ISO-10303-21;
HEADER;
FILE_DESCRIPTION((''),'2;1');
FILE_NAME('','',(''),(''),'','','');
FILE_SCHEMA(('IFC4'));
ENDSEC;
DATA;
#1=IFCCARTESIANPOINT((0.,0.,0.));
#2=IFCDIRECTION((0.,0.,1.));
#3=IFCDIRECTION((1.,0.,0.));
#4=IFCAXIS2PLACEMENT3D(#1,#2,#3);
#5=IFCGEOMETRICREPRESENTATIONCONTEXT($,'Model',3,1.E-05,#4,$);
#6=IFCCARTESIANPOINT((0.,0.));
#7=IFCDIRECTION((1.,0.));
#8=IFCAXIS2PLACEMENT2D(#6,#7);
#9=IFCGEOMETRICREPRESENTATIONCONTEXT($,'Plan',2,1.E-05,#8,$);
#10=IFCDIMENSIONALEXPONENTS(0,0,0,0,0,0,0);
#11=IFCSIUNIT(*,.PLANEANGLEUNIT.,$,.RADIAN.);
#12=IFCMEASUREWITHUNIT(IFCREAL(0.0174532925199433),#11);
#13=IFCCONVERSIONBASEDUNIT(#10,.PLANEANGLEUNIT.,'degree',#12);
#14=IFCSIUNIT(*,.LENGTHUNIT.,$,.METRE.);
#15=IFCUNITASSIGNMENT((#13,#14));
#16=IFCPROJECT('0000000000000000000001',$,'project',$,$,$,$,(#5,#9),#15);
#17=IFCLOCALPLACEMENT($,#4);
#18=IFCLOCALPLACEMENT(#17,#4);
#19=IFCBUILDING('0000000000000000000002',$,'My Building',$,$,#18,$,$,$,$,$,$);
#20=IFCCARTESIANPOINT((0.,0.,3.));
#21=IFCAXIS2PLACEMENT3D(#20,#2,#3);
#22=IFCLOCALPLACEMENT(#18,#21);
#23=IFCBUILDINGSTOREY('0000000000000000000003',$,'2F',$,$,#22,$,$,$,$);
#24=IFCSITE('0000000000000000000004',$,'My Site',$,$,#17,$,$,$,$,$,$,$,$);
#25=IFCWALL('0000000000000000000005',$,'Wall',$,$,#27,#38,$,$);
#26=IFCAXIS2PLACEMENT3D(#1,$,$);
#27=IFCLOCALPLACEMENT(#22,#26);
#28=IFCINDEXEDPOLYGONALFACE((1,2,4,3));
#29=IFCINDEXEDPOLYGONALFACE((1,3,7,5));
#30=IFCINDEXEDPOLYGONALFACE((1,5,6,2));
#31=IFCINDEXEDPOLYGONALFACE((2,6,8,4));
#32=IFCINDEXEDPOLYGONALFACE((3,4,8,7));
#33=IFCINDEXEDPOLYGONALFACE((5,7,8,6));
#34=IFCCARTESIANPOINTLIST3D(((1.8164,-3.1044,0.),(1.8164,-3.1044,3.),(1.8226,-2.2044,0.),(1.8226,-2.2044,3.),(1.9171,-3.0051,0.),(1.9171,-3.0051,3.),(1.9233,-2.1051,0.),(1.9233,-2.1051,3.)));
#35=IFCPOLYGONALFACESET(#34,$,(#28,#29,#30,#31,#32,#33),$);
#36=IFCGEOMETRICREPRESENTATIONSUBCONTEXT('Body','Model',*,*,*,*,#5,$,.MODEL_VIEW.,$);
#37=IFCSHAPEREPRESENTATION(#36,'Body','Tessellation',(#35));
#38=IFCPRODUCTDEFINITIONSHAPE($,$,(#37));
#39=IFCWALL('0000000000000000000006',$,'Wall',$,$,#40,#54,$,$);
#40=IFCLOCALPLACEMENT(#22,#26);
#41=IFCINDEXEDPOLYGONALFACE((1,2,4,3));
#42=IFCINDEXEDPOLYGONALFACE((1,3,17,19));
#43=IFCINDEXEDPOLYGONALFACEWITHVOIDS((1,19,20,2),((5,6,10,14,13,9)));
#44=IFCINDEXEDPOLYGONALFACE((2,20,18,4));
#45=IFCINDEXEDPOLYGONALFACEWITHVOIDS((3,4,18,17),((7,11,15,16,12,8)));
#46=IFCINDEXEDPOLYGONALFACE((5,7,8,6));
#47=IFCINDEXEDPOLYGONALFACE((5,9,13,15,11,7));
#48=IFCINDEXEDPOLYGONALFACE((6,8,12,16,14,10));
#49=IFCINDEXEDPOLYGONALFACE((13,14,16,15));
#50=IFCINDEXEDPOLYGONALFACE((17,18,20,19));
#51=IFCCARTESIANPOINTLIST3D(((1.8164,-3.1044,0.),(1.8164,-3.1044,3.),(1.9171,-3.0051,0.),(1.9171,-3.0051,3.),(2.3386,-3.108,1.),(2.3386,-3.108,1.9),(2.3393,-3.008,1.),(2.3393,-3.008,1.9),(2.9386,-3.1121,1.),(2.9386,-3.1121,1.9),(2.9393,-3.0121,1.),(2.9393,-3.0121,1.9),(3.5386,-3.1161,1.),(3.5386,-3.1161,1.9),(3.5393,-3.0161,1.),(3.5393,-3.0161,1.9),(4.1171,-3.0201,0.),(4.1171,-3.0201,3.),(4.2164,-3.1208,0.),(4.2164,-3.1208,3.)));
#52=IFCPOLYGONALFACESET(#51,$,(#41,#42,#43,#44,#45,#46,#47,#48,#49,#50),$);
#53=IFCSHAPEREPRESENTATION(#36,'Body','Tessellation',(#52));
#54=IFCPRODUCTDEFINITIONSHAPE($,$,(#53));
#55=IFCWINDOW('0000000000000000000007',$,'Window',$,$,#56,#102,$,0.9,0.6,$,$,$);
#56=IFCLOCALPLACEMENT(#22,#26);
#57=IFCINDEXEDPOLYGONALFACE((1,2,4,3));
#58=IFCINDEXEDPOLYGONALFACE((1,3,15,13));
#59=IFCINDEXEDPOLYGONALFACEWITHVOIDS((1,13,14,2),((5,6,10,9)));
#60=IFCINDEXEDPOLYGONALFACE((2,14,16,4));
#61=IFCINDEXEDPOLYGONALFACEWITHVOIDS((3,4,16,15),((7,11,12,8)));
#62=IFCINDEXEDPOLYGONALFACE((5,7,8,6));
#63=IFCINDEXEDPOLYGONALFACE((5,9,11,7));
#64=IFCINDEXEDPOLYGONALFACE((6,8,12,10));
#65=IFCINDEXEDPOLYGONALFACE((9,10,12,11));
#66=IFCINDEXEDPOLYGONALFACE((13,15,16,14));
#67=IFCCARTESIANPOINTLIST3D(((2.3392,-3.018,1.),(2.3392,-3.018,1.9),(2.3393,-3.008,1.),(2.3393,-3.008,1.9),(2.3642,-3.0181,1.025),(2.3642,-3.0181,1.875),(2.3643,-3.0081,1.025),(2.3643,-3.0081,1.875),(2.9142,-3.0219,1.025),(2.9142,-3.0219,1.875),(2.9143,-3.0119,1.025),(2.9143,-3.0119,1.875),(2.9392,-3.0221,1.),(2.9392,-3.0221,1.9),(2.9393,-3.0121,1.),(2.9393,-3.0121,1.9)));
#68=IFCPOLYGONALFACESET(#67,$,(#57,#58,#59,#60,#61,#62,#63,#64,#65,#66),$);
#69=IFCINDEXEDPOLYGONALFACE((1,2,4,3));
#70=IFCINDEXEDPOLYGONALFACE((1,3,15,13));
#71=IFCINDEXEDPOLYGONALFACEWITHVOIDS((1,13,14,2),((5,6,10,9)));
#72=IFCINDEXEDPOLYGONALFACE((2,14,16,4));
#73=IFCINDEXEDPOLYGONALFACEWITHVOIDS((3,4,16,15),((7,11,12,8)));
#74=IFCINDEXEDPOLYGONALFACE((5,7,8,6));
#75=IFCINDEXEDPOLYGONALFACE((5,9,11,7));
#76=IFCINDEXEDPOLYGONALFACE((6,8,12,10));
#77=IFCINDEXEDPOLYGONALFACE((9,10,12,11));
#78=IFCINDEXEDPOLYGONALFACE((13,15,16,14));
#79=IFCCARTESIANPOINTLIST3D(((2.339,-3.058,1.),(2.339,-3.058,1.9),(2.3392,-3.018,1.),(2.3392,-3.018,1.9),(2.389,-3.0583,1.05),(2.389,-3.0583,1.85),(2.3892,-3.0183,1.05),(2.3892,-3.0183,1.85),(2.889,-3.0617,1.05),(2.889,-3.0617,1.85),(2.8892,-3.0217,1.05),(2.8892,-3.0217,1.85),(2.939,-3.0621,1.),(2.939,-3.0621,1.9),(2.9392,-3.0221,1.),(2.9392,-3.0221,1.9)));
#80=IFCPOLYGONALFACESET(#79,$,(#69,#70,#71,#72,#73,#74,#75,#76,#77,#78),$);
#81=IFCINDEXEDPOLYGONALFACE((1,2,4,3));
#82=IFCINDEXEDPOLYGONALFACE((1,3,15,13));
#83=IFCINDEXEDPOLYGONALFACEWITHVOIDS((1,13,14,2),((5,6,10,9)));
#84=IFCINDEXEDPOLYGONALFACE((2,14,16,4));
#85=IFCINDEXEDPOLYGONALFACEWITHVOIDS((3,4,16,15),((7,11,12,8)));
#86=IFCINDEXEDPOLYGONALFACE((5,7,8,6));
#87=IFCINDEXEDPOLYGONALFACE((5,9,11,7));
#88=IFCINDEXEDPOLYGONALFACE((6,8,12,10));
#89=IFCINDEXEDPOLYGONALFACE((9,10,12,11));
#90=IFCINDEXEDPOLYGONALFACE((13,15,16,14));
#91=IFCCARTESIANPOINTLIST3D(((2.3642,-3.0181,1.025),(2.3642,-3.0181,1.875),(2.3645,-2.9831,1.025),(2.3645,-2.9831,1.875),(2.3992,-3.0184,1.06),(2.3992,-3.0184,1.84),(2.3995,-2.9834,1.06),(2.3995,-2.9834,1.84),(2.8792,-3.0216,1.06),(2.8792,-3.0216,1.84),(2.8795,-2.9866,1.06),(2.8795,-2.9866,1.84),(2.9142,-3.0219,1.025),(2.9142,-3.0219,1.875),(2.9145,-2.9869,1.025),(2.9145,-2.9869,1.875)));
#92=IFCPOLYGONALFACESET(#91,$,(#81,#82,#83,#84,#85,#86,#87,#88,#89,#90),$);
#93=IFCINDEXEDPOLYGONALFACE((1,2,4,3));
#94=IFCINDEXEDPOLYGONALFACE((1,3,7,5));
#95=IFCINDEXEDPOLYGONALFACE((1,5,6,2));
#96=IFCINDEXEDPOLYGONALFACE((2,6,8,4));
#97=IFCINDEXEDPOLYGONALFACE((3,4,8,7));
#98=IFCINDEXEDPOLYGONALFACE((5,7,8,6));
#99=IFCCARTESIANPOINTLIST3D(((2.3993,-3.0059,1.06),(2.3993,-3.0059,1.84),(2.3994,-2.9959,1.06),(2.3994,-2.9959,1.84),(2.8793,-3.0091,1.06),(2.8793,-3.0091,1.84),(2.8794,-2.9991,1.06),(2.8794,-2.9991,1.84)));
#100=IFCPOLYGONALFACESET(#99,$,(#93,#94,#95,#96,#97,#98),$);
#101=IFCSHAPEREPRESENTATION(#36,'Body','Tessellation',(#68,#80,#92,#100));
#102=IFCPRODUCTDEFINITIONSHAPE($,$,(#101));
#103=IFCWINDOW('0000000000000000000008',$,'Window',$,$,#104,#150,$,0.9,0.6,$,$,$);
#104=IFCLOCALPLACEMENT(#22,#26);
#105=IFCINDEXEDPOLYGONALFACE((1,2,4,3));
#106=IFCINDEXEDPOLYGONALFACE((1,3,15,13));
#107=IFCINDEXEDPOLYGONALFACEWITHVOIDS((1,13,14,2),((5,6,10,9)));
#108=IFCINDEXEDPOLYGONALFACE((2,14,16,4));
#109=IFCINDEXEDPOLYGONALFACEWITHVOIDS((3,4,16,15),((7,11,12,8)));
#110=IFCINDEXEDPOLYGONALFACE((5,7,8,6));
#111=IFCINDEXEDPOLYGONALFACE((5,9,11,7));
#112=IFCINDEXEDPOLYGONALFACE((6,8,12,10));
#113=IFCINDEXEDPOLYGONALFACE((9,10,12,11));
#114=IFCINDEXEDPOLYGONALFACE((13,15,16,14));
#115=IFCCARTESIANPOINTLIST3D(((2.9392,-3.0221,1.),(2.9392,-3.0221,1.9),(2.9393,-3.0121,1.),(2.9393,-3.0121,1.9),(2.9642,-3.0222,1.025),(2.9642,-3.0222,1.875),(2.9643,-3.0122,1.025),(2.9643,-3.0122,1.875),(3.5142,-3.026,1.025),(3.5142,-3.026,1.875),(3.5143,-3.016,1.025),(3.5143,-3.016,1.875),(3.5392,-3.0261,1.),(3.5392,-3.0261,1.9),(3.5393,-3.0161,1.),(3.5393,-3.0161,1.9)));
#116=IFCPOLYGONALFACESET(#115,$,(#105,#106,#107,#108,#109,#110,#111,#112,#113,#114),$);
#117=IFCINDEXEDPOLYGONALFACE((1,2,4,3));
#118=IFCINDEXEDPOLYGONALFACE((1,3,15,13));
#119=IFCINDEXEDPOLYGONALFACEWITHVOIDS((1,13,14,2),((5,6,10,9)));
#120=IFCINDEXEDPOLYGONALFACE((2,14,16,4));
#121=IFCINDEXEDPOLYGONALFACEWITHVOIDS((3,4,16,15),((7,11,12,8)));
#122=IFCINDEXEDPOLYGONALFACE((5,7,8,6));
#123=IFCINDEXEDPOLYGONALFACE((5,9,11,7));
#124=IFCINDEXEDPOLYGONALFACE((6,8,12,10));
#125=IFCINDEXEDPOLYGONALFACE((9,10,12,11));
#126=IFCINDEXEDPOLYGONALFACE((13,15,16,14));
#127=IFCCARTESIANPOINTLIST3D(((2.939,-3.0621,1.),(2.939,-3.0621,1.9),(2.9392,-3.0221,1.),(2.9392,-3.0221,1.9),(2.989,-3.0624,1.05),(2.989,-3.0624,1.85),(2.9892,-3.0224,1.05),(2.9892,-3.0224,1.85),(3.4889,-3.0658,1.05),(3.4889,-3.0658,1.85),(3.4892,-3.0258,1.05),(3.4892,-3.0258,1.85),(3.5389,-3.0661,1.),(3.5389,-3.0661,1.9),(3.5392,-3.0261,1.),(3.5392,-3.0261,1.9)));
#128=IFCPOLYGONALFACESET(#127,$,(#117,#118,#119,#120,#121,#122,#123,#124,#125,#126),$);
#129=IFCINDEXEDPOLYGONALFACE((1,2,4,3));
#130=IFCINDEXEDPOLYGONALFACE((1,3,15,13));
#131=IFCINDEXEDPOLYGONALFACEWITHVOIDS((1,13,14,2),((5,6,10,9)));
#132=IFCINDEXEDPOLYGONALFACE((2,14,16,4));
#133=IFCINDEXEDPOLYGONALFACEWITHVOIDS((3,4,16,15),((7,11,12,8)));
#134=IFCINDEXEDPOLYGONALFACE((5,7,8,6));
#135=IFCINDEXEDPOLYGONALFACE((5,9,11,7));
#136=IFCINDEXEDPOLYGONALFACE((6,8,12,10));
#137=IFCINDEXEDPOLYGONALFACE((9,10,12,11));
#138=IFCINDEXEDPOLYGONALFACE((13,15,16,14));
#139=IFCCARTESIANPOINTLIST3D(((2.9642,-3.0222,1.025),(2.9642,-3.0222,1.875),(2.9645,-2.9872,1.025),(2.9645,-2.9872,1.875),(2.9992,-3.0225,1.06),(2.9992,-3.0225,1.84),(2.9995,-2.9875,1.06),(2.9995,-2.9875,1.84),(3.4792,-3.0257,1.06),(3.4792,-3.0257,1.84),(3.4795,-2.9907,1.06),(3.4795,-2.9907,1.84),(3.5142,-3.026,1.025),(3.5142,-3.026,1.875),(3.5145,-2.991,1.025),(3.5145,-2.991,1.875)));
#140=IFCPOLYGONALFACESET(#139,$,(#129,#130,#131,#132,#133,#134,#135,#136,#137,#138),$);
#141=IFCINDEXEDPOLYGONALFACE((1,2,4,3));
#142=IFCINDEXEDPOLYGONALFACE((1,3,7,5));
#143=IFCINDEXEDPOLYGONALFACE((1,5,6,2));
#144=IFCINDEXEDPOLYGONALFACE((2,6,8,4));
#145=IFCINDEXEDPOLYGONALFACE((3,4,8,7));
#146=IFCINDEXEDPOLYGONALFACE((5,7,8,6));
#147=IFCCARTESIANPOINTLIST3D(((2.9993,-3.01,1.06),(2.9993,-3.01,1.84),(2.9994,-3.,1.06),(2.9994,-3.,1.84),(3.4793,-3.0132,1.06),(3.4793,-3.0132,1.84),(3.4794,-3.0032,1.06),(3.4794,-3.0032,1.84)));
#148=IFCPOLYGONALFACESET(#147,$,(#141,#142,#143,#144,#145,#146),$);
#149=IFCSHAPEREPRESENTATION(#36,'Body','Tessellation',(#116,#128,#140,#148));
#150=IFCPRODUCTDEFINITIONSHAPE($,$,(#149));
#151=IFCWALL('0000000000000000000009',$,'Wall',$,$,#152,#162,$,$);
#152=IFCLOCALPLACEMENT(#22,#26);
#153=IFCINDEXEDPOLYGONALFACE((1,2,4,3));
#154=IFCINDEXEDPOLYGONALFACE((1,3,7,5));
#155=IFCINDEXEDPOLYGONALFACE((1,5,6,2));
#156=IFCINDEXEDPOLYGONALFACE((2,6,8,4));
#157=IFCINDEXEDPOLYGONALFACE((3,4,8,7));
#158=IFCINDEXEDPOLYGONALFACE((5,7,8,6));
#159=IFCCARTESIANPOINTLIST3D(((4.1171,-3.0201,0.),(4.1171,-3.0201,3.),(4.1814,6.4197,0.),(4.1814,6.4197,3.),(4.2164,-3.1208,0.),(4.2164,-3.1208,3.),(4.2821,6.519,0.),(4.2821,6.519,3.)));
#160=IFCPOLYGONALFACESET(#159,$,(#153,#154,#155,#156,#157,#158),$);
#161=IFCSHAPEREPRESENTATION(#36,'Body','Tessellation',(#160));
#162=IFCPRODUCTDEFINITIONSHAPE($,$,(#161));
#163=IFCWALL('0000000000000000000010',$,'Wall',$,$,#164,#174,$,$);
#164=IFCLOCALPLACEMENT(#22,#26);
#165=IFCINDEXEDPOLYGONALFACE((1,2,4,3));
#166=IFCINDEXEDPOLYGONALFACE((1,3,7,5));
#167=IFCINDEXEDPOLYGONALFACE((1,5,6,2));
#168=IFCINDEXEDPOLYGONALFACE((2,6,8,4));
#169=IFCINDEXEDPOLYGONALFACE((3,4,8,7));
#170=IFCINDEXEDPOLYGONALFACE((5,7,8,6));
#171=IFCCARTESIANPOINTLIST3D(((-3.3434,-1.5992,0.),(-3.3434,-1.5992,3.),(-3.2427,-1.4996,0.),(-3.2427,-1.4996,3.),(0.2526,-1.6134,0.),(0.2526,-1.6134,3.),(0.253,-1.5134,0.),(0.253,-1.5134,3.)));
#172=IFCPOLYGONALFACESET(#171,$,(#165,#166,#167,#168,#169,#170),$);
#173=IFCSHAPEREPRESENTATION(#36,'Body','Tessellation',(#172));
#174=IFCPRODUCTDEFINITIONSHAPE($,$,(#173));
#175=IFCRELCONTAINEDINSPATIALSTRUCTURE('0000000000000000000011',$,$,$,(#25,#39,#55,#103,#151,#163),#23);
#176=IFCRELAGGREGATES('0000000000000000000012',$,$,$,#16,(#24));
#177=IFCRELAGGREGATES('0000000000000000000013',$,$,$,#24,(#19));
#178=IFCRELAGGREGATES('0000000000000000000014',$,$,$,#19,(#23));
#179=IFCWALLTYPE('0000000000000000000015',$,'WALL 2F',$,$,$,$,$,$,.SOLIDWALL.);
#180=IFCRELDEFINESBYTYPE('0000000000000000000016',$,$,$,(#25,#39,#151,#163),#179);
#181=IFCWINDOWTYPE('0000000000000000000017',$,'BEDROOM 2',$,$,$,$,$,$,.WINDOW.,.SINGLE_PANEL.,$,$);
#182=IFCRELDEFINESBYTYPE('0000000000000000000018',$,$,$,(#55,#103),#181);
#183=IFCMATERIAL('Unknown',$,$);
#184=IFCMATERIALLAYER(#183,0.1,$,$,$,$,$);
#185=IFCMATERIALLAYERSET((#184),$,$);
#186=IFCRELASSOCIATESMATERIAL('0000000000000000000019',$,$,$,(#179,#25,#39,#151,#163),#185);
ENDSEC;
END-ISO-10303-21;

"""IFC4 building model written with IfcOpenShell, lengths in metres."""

from ifc_helpers import new_model, entity, si_unit, converted_unit, frame, origin_with_axes, origin_2d_with_axis, place, context, subcontext, project, spatial, line, indexed_curve, outline, extrude, shape, source, transform, mapped, material, layer, layer_set, layer_usage, type_object, type_shapes, element, fill, save


model = new_model("IFC4")

# Units and contexts
model_context = context("Model", 3, precision=1e-05, world=origin_with_axes())
plan_context = context("Plan", 2, precision=1e-05, world=origin_2d_with_axis())
body_context_1 = subcontext(model_context, "Body", "Model", "MODEL_VIEW")
body_context_2 = subcontext(plan_context, "Body", "Plan", "PLAN_VIEW")
ifc_project = project(units=[converted_unit("PLANEANGLEUNIT", "degree", entity("IfcReal", 0.0174532925199433), si_unit("PLANEANGLEUNIT", "RADIAN"), dimensions=[0, 0, 0, 0, 0, 0, 0]), si_unit("LENGTHUNIT", "METRE")], contexts=[model_context, plan_context])

# Site, building, storey
site_placement = place(None, origin_with_axes())
site = spatial("IfcSite", under=ifc_project, at=site_placement, Name="My Site")
building_placement = place(site_placement, origin_with_axes())
building = spatial("IfcBuilding", under=site, at=building_placement, Name="My Building")
storey_placement = place(building_placement, frame((0.0, 0.0, 3.0), z_axis=(0.0, 0.0, 1.0), x_axis=(1.0, 0.0, 0.0)))
storey = spatial("IfcBuildingStorey", under=building, at=storey_placement, Name="2F")

# Shared definitions
ifc_material = material(Name="Unknown")
ifc_layer = layer(ifc_material, 0.1)
ifc_layer_set = layer_set([ifc_layer])
wall_type = type_object("IfcWallType", Name="WALL 2F", PredefinedType="SOLIDWALL", material=ifc_layer_set)

# Wall
ifc_layer_usage_1 = layer_usage(ifc_layer_set, "AXIS2", "POSITIVE", 0.0)
wall_1_placement = place(storey_placement, frame((1.8226, -2.2044, 0.0), z_axis=(0.0, 0.0, 1.0), x_axis=(-0.006814, -0.999977, 0.0)))
element("IfcWall", 1, at=wall_1_placement, inside=storey, type_object=wall_type, material=ifc_layer_usage_1, Name="Wall", context=body_context_1, shape_type="SweptSolid", body=[
    extrude(outline(indexed_curve([(0.0, 0.0), (-0.1, 0.1), (0.8, 0.1), (0.9, 0.0)], segments=[line(1, 2, 3, 4, 1)])), origin_with_axes(), (0.0, 0.0, 1.0), 3.0),
])

# Wall, openings, windows
ifc_layer_usage_2 = layer_usage(ifc_layer_set, "AXIS2", "POSITIVE", 0.0)
wall_2_placement = place(storey_placement, frame((1.8164, -3.1044, 0.0), z_axis=(0.0, 0.0, 1.0), x_axis=(0.999977, -0.006814, 0.0)))
wall_2 = element("IfcWall", 2, at=wall_2_placement, inside=storey, type_object=wall_type, material=ifc_layer_usage_2, Name="Wall", context=body_context_1, shape_type="SweptSolid", body=[
    extrude(outline(indexed_curve([(0.0, 0.0), (0.1, 0.1), (2.3, 0.1), (2.4, 0.0)], segments=[line(1, 2, 3, 4, 1)])), origin_with_axes(), (0.0, 0.0, 1.0), 3.0),
])
shared_shape_1 = source(origin_with_axes(), body_context_1, "Body", "SweptSolid", [
    extrude(outline(indexed_curve([(0.0, 0.0), (0.6, 0.0), (0.6, 0.9), (0.0, 0.9)], segments=[line(1, 2, 3, 4, 1)])), frame((0.0, -0.6, 0.0), z_axis=(0.0, -1.0, 0.0), x_axis=(1.0, 0.0, 0.0)), (0.0, 0.0, -1.0), 1.2),
])
opening_1_placement = place(wall_2_placement, frame((0.5222, 0.0, 1.0), z_axis=(0.0, 0.0, 1.0), x_axis=(1.0, 0.0, 0.0)))
opening_1 = element("IfcOpeningElement", 3, at=opening_1_placement, cuts=wall_2, PredefinedType="OPENING", context=body_context_1, shape_type="MappedRepresentation", body=[
    mapped(shared_shape_1, transform((0.0, 0.0, 0.0), x_axis=(1.0, 0.0, 0.0), y_axis=(0.0, 1.0, 0.0), z_axis=(0.0, 0.0, 1.0), scale=1.0)),
])
opening_2_placement = place(wall_2_placement, frame((1.1222, 0.0, 1.0), z_axis=(0.0, 0.0, 1.0), x_axis=(1.0, 0.0, 0.0)))
opening_2 = element("IfcOpeningElement", 4, at=opening_2_placement, cuts=wall_2, PredefinedType="OPENING", context=body_context_1, shape_type="MappedRepresentation", body=[
    mapped(shared_shape_1, transform((0.0, 0.0, 0.0), x_axis=(1.0, 0.0, 0.0), y_axis=(0.0, 1.0, 0.0), z_axis=(0.0, 0.0, 1.0), scale=1.0)),
])
window_type = type_object("IfcWindowType", Name="BEDROOM 2", PartitioningType="SINGLE_PANEL", PredefinedType="WINDOW")
shared_shape_2 = source(origin_with_axes(), body_context_1, "Body", "SweptSolid", [
    extrude(outline(indexed_curve([(0.0, 0.0), (0.6, 0.0), (0.6, 0.9), (0.0, 0.9)], segments=[line(1, 2, 3, 4, 1)]), holes=[indexed_curve([(0.025, 0.025), (0.575, 0.025), (0.575, 0.875), (0.025, 0.875)], segments=[line(1, 2, 3, 4, 1)])]), frame((0.0, 0.09, 0.0), z_axis=(0.0, -1.0, 0.0), x_axis=(1.0, 0.0, 0.0)), (0.0, 0.0, -1.0), 0.01),
    extrude(outline(indexed_curve([(0.0, 0.0), (0.6, 0.0), (0.6, 0.9), (0.0, 0.9)], segments=[line(1, 2, 3, 4, 1)]), holes=[indexed_curve([(0.05, 0.05), (0.55, 0.05), (0.55, 0.85), (0.05, 0.85)], segments=[line(1, 2, 3, 4, 1)])]), frame((0.0, 0.05, 0.0), z_axis=(0.0, -1.0, 0.0), x_axis=(1.0, 0.0, 0.0)), (0.0, 0.0, -1.0), 0.04),
    extrude(outline(indexed_curve([(0.0, 0.0), (0.55, 0.0), (0.55, 0.85), (0.0, 0.85)], segments=[line(1, 2, 3, 4, 1)]), holes=[indexed_curve([(0.035, 0.035), (0.515, 0.035), (0.515, 0.815), (0.035, 0.815)], segments=[line(1, 2, 3, 4, 1)])]), frame((0.025, 0.09, 0.025), z_axis=(0.0, -1.0, 0.0), x_axis=(1.0, 0.0, 0.0)), (0.0, 0.0, -1.0), 0.035),
    extrude(outline(indexed_curve([(0.035, 0.035), (0.515, 0.035), (0.515, 0.815), (0.035, 0.815)], segments=[line(1, 2, 3, 4, 1)])), frame((0.025, 0.1025, 0.025), z_axis=(0.0, -1.0, 0.0), x_axis=(1.0, 0.0, 0.0)), (0.0, 0.0, -1.0), 0.01),
])
shared_shape_3 = source(origin_with_axes(), body_context_2, "Body", "Curve2D", [
    entity("IfcIndexedPolyCurve", entity("IfcCartesianPointList2D", [[0.05, 0.05], [0.55, 0.05]])),
    entity("IfcIndexedPolyCurve", entity("IfcCartesianPointList2D", [[0.0, 0.1], [0.025, 0.1], [0.025, 0.09], [0.05, 0.09], [0.05, 0.05], [0.0, 0.05]]), [entity("IfcLineIndex", [1, 2, 3, 4, 5, 6, 1])]),
    entity("IfcIndexedPolyCurve", entity("IfcCartesianPointList2D", [[0.6, 0.1], [0.575, 0.1], [0.575, 0.09], [0.55, 0.09], [0.55, 0.05], [0.6, 0.05]]), [entity("IfcLineIndex", [1, 2, 3, 4, 5, 6, 1])]),
    entity("IfcIndexedPolyCurve", entity("IfcCartesianPointList2D", [[0.025, 0.09], [0.06, 0.09], [0.06, 0.125], [0.025, 0.125]]), [entity("IfcLineIndex", [1, 2, 3, 4, 1])]),
    entity("IfcIndexedPolyCurve", entity("IfcCartesianPointList2D", [[0.575, 0.09], [0.54, 0.09], [0.54, 0.125], [0.575, 0.125]]), [entity("IfcLineIndex", [1, 2, 3, 4, 1])]),
    entity("IfcIndexedPolyCurve", entity("IfcCartesianPointList2D", [[0.06, 0.09], [0.54, 0.09]])),
    entity("IfcIndexedPolyCurve", entity("IfcCartesianPointList2D", [[0.06, 0.125], [0.54, 0.125]])),
    entity("IfcIndexedPolyCurve", entity("IfcCartesianPointList2D", [[0.06, 0.1075], [0.54, 0.1075]])),
])
type_shapes(window_type, [shared_shape_2, shared_shape_3])
window_1_placement = place(opening_1_placement, frame((0.0, 0.0, 0.0), z_axis=(0.0, 0.0, 1.0), x_axis=(1.0, 0.0, 0.0)))
window_1 = element("IfcWindow", 5, at=window_1_placement, inside=storey, type_object=window_type, Name="Window", OverallHeight=0.9, OverallWidth=0.6, shapes=[
    shape(body_context_1, "Body", "MappedRepresentation", [mapped(shared_shape_2, transform((0.0, 0.0, 0.0), x_axis=(1.0, 0.0, 0.0), y_axis=(0.0, 1.0, 0.0), z_axis=(0.0, 0.0, 1.0), scale=1.0))]),
    shape(body_context_2, "Body", "MappedRepresentation", [mapped(shared_shape_3, transform((0.0, 0.0, 0.0), x_axis=(1.0, 0.0, 0.0), y_axis=(0.0, 1.0, 0.0), z_axis=(0.0, 0.0, 1.0), scale=1.0))]),
])
fill(opening_1, window_1)
window_2_placement = place(opening_2_placement, frame((0.0, 0.0, 0.0), z_axis=(0.0, 0.0, 1.0), x_axis=(1.0, 0.0, 0.0)))
window_2 = element("IfcWindow", 6, at=window_2_placement, inside=storey, type_object=window_type, Name="Window", OverallHeight=0.9, OverallWidth=0.6, shapes=[
    shape(body_context_1, "Body", "MappedRepresentation", [mapped(shared_shape_2, transform((0.0, 0.0, 0.0), x_axis=(1.0, 0.0, 0.0), y_axis=(0.0, 1.0, 0.0), z_axis=(0.0, 0.0, 1.0), scale=1.0))]),
    shape(body_context_2, "Body", "MappedRepresentation", [mapped(shared_shape_3, transform((0.0, 0.0, 0.0), x_axis=(1.0, 0.0, 0.0), y_axis=(0.0, 1.0, 0.0), z_axis=(0.0, 0.0, 1.0), scale=1.0))]),
])
fill(opening_2, window_2)

# Walls
ifc_layer_usage_3 = layer_usage(ifc_layer_set, "AXIS2", "POSITIVE", 0.0)
wall_3_placement = place(storey_placement, frame((4.2164, -3.1208, 0.0), z_axis=(0.0, 0.0, 1.0), x_axis=(0.006815, 0.999977, 0.0)))
element("IfcWall", 7, at=wall_3_placement, inside=storey, type_object=wall_type, material=ifc_layer_usage_3, Name="Wall", context=body_context_1, shape_type="SweptSolid", body=[
    extrude(outline(indexed_curve([(0.0, 0.0), (0.1, 0.1), (9.54, 0.1), (9.64, 0.0)], segments=[line(1, 2, 3, 4, 1)])), origin_with_axes(), (0.0, 0.0, 1.0), 3.0),
])
ifc_layer_usage_4 = layer_usage(ifc_layer_set, "AXIS2", "POSITIVE", 0.0)
wall_4_placement = place(storey_placement, frame((-3.3434, -1.5992, 0.0), z_axis=(0.0, 0.0, 1.0), x_axis=(0.999992, -0.00396, 0.0)))
element("IfcWall", 8, at=wall_4_placement, inside=storey, type_object=wall_type, material=ifc_layer_usage_4, Name="Wall", context=body_context_1, shape_type="SweptSolid", body=[
    extrude(outline(indexed_curve([(0.0, 0.0), (0.1003, 0.1), (3.5961, 0.1), (3.5961, 0.0)], segments=[line(1, 2, 3, 4, 1)])), origin_with_axes(), (0.0, 0.0, 1.0), 3.0),
])

save(model, "model.ifc")
